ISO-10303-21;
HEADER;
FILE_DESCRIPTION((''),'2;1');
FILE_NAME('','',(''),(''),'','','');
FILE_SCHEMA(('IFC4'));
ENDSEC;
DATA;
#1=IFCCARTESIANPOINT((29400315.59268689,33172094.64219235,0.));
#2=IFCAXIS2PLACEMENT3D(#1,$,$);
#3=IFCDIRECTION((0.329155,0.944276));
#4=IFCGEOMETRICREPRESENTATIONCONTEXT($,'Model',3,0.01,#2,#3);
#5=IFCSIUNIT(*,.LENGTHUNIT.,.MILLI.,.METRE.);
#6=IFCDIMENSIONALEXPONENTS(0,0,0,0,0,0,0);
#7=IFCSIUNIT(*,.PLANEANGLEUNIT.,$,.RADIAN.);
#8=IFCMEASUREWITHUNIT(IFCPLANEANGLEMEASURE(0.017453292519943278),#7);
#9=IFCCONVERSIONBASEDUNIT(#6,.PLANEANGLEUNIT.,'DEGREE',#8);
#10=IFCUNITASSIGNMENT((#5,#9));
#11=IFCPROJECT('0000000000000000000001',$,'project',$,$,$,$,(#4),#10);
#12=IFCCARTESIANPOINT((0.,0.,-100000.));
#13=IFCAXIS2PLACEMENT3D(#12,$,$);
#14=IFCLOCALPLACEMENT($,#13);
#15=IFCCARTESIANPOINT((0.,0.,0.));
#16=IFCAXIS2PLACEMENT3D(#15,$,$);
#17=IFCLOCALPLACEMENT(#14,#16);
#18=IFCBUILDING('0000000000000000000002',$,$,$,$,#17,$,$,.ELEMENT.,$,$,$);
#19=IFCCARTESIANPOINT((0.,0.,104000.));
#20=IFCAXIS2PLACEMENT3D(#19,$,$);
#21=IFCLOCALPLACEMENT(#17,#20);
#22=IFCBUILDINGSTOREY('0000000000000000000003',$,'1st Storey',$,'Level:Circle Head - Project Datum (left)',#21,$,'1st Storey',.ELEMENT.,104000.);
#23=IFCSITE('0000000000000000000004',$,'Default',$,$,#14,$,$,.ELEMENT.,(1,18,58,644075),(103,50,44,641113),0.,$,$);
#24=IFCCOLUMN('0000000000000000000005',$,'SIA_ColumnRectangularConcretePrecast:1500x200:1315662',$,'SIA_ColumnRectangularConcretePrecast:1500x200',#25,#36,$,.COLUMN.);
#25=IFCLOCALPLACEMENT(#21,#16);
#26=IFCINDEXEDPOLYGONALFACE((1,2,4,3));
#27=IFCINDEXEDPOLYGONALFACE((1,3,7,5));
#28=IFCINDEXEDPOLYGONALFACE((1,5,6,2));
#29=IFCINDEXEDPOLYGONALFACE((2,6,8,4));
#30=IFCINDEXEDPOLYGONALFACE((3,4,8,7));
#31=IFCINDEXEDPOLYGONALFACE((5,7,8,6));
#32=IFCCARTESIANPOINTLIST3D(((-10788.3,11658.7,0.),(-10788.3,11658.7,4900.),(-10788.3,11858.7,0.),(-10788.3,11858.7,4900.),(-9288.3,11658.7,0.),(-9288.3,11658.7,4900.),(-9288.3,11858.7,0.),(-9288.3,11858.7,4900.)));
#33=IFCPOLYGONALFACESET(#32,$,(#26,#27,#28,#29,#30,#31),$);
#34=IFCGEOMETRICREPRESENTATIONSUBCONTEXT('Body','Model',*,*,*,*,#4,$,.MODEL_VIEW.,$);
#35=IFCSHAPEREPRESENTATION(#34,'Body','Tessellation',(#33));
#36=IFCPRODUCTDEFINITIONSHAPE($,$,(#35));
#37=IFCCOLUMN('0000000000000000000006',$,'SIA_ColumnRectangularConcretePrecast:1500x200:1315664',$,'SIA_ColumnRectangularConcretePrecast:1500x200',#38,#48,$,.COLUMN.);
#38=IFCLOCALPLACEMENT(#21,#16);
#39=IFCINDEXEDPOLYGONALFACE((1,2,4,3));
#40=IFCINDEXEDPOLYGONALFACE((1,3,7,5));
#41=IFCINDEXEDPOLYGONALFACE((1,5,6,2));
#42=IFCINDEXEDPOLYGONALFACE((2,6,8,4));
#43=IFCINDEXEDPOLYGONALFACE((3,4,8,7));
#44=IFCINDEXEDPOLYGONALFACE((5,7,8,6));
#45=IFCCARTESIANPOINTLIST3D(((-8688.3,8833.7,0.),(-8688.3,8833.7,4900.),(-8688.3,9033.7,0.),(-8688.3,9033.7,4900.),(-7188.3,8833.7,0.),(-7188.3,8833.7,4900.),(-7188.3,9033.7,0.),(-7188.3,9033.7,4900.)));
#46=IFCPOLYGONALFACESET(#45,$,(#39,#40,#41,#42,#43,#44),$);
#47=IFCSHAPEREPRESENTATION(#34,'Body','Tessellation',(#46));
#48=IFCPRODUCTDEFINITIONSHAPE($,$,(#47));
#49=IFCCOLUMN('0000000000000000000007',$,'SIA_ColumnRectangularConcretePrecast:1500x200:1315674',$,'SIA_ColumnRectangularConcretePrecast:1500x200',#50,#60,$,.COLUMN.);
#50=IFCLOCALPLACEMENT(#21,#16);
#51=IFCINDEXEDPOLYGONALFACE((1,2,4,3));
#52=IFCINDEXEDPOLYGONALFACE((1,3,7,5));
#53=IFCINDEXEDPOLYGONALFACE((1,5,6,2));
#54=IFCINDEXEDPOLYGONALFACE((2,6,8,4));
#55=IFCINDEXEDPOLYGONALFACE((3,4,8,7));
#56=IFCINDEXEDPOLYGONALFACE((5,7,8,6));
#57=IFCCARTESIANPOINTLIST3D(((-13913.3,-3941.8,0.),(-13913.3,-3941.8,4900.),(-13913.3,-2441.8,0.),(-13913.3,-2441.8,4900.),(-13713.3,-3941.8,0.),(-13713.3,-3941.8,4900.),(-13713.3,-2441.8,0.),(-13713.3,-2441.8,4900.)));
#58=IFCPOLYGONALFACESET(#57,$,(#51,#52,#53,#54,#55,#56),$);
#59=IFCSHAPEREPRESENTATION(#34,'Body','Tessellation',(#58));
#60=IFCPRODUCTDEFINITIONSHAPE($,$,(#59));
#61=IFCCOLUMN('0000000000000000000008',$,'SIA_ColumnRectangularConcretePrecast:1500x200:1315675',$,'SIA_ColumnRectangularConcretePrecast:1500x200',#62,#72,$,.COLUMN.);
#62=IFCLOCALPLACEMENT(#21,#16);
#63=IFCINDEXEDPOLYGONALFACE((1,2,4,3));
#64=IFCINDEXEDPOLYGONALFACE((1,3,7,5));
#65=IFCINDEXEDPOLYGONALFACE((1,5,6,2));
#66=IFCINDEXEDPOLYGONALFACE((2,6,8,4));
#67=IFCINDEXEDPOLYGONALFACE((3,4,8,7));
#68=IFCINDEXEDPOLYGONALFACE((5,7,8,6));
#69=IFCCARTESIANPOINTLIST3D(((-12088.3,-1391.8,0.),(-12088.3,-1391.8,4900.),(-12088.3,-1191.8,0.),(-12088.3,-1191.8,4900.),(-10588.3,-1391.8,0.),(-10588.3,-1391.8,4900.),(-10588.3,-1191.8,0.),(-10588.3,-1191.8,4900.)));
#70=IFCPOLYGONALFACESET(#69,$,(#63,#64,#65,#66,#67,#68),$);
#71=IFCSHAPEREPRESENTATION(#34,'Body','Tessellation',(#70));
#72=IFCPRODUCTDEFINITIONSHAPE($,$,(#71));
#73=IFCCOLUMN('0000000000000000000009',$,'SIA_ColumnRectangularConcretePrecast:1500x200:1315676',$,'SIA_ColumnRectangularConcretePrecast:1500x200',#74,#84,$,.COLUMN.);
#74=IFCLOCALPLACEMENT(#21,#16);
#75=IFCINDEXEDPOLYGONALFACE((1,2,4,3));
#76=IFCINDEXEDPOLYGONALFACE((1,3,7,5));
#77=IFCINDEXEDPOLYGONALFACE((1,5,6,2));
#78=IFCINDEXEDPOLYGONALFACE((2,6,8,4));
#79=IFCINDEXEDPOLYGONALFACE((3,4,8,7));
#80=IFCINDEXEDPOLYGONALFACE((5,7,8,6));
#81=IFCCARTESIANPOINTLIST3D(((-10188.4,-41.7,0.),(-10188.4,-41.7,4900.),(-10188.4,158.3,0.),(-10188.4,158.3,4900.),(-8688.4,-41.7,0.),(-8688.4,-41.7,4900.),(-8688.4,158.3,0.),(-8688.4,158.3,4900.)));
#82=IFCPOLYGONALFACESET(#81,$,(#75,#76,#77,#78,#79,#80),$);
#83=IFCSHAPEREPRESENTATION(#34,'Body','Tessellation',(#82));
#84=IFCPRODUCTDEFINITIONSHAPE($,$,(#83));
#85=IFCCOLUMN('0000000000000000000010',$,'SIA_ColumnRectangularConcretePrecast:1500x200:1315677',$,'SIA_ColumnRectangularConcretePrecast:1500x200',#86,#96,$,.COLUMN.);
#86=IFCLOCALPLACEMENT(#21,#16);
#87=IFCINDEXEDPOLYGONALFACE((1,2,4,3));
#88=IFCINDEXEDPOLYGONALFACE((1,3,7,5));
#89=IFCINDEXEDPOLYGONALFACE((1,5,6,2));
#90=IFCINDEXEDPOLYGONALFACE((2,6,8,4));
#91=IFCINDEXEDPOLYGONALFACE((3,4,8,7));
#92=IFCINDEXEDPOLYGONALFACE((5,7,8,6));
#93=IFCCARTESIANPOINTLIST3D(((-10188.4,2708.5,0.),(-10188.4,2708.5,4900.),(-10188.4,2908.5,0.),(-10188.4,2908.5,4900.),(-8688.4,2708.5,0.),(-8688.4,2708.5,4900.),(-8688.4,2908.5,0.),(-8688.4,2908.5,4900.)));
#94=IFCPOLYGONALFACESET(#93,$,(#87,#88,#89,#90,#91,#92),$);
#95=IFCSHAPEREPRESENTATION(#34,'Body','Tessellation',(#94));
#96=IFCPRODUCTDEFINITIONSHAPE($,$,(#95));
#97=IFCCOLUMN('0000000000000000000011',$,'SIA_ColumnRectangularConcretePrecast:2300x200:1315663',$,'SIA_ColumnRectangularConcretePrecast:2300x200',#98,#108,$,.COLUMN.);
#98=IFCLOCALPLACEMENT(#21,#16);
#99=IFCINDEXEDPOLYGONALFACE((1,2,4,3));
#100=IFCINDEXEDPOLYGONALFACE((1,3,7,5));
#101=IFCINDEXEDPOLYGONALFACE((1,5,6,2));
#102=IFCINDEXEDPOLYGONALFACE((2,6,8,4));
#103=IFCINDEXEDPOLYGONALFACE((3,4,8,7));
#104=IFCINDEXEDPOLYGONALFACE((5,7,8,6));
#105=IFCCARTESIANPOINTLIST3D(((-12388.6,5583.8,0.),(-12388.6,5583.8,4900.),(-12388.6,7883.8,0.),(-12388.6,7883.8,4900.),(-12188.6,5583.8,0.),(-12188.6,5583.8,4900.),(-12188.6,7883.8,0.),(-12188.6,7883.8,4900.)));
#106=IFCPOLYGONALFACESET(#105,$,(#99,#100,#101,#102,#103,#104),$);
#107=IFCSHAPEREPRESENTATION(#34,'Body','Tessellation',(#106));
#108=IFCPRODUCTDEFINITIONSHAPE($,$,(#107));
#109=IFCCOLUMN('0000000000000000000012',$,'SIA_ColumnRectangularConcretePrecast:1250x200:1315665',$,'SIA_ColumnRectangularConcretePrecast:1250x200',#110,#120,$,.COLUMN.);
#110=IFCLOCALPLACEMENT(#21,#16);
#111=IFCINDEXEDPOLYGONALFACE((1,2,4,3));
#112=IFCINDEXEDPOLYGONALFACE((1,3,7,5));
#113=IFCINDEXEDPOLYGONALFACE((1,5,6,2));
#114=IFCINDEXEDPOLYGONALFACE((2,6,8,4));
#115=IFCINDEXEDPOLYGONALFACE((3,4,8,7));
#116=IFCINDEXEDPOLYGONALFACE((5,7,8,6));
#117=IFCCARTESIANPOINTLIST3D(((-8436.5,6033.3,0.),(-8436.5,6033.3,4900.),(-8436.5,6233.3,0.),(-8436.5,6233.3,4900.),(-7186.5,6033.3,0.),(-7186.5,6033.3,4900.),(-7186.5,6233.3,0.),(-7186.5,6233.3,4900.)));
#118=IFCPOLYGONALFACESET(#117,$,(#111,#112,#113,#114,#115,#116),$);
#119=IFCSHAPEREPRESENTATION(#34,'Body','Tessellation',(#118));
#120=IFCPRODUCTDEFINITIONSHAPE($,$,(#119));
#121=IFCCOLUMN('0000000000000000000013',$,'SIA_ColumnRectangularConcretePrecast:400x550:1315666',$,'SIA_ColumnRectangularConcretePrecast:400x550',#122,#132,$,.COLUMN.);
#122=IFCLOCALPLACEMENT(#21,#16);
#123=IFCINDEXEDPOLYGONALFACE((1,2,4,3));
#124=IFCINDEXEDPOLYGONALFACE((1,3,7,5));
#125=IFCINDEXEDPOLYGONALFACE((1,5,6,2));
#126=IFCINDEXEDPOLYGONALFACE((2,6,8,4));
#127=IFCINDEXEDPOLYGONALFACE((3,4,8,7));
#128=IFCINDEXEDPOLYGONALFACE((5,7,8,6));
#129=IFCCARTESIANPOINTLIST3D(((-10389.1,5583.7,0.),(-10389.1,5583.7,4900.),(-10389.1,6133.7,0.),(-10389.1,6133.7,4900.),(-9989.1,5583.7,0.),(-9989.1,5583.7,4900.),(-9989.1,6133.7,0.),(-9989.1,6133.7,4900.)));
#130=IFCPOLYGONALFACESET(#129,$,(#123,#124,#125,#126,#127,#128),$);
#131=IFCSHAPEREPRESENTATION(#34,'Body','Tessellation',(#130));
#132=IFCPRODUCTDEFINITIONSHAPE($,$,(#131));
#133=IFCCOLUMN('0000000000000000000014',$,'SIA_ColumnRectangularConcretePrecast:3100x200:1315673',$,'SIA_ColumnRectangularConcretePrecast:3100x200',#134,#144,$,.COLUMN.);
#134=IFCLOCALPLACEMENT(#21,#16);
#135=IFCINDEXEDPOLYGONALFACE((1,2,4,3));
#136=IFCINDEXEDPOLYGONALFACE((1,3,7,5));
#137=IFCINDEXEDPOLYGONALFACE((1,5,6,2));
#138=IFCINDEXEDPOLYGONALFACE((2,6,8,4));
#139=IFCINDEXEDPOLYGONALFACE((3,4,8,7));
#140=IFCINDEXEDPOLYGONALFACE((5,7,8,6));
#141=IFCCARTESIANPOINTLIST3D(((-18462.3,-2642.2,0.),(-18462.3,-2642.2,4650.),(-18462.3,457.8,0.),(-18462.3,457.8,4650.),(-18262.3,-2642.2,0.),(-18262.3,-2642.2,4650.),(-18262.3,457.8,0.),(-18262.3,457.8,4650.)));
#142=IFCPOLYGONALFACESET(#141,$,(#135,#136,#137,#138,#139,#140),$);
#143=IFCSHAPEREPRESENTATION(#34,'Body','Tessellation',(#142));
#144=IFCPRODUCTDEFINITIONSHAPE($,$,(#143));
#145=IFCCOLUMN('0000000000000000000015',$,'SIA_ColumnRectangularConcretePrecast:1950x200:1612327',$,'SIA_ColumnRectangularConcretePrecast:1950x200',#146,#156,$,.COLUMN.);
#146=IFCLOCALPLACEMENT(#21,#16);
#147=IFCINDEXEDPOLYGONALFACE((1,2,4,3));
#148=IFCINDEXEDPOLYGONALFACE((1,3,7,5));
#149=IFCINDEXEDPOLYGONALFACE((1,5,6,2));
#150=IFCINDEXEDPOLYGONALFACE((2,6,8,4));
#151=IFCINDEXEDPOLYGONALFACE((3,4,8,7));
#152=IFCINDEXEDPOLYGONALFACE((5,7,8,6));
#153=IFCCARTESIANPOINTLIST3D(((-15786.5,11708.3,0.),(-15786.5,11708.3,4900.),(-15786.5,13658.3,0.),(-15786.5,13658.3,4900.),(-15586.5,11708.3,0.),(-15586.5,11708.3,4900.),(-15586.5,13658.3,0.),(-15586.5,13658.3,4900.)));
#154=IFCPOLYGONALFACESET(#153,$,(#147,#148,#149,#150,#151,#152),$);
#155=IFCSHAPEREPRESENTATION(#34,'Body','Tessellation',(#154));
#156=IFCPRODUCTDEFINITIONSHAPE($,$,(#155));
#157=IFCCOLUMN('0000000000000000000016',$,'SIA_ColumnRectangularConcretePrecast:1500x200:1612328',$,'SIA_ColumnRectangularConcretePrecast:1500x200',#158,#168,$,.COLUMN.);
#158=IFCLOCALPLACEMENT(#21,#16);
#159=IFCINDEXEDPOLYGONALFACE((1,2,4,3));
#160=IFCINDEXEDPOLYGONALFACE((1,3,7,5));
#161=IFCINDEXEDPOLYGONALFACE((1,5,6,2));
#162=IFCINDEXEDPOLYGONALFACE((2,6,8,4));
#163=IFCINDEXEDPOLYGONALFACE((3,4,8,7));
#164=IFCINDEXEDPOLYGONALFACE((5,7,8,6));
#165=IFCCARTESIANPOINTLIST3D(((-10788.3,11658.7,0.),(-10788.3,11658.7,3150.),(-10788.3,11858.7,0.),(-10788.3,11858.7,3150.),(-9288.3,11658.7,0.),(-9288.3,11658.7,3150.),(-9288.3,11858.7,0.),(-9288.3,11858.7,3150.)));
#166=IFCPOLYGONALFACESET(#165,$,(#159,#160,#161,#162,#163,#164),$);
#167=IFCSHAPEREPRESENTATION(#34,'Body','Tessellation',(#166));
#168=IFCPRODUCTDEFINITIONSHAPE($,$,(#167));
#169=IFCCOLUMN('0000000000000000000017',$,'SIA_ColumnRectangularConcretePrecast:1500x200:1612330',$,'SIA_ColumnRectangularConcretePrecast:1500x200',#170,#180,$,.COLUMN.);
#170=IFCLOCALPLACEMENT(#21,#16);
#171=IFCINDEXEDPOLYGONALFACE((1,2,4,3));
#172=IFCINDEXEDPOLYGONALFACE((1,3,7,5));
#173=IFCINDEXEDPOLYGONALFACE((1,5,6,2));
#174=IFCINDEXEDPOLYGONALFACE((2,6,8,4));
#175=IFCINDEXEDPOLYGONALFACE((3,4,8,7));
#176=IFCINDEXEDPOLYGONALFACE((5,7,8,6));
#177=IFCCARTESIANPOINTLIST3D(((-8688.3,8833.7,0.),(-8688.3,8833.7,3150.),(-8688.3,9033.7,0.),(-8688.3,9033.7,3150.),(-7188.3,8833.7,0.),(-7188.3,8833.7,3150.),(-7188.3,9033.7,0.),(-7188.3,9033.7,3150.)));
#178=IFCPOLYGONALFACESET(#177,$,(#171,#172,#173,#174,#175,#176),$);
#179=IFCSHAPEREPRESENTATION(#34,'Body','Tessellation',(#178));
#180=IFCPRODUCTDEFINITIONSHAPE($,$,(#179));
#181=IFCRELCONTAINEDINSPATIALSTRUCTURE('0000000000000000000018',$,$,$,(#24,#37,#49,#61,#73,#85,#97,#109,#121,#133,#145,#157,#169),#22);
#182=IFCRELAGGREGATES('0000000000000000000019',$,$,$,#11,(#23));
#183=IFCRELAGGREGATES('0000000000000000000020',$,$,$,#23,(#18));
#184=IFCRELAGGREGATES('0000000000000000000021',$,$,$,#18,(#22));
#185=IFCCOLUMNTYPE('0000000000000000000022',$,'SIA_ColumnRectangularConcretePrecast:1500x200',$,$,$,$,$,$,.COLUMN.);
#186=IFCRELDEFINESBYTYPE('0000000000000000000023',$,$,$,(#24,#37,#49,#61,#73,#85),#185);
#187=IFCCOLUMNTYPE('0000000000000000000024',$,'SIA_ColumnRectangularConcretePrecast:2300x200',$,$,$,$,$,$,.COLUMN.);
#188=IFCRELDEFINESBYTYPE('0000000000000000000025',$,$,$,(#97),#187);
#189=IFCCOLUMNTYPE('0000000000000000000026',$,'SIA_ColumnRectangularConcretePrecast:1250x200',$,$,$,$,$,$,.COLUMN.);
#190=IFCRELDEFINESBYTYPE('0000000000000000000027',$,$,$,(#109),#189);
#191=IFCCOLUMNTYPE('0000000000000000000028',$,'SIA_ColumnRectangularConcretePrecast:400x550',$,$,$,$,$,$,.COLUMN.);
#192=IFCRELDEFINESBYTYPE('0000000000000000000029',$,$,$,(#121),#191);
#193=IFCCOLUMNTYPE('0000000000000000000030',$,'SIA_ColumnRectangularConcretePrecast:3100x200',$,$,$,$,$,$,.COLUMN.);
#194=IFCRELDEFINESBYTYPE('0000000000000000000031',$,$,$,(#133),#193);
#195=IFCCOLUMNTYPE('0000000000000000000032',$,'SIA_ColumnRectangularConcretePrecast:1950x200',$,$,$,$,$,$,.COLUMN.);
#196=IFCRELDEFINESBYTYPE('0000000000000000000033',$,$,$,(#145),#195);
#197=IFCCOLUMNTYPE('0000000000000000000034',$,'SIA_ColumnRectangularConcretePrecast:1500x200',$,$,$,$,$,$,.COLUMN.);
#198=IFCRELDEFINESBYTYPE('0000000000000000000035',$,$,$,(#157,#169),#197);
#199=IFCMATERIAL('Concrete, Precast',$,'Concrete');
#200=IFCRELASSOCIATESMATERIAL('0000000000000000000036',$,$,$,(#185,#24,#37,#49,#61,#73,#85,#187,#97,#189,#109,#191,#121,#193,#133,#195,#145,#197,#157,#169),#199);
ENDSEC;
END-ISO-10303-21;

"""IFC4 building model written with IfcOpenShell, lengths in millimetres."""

from ifc_helpers import new_model, entity, si_unit, converted_unit, direction, frame, origin, place, context, subcontext, project, spatial, indexed_curve, outline, extrude, source, transform, mapped, material, type_object, type_shapes, element, save


model = new_model("IFC4")

# Units and contexts
model_context = context("Model", 3, precision=0.01, world=frame((29400315.59268689, 33172094.64219235, 0.0)), true_north=direction((0.329155, 0.944276)))
body_context = subcontext(model_context, "Body", "Model", "MODEL_VIEW")
ifc_project = project(units=[si_unit("LENGTHUNIT", "METRE", prefix="MILLI"), converted_unit("PLANEANGLEUNIT", "DEGREE", entity("IfcPlaneAngleMeasure", 0.017453292519943278), si_unit("PLANEANGLEUNIT", "RADIAN"), dimensions=[0, 0, 0, 0, 0, 0, 0])], contexts=[model_context])

# Site, building, storey
site_placement = place(None, frame((0.0, 0.0, -100000.0)))
site = spatial("IfcSite", under=ifc_project, at=site_placement, Name="Default", CompositionType="ELEMENT", RefLatitude=(1, 18, 58, 644075), RefLongitude=(103, 50, 44, 641113), RefElevation=0.0)
building_placement = place(site_placement, origin())
building = spatial("IfcBuilding", under=site, at=building_placement, CompositionType="ELEMENT")
storey_placement = place(building_placement, frame((0.0, 0.0, 104000.0)))
storey = spatial("IfcBuildingStorey", under=building, at=storey_placement, Name="1st Storey", ObjectType="Level:Circle Head - Project Datum (left)", LongName="1st Storey", CompositionType="ELEMENT", Elevation=104000.0)

# Columns
ifc_material = material(Name="Concrete, Precast", Category="Concrete")
column_type_1 = type_object("IfcColumnType", Name="SIA_ColumnRectangularConcretePrecast:1500x200", PredefinedType="COLUMN", material=ifc_material)
shared_shape_1 = source(origin(), body_context, "Body", "SweptSolid", [
    extrude(outline(indexed_curve([(-100.0, -750.0), (100.0, -750.0), (100.0, 750.0), (-100.0, 750.0), (-100.0, -750.0)], self_intersect=False)), frame((0.0, 0.0, 104000.0), z_axis=(0.0, 0.0, 1.0), x_axis=(-1.0, 0.0, 0.0)), (0.0, 0.0, 1.0), 4900.0),
])
type_shapes(column_type_1, [shared_shape_1])
for number, where, z_axis, x_axis, name in (
    (1, (-10038.3, 11758.7, -104000.0), (0.0, 0.0, 1.0), (0.0, -1.0, 0.0), "SIA_ColumnRectangularConcretePrecast:1500x200:1315662"),
    (2, (-7938.3, 8933.7, -104000.0), (0.0, 0.0, 1.0), (0.0, 1.0, 0.0), "SIA_ColumnRectangularConcretePrecast:1500x200:1315664"),
):
    element("IfcColumn", number, at=place(storey_placement, frame(where, z_axis=z_axis, x_axis=x_axis)), inside=storey, type_object=column_type_1, material=ifc_material, Name=name, ObjectType="SIA_ColumnRectangularConcretePrecast:1500x200", PredefinedType="COLUMN", context=body_context, shape_type="MappedRepresentation", body=[
        mapped(shared_shape_1, transform((0.0, 0.0, 0.0), scale=1.0)),
    ])
column_1_placement = place(storey_placement, frame((-13813.3, -3191.8, -104000.0)))
element("IfcColumn", 3, at=column_1_placement, inside=storey, type_object=column_type_1, material=ifc_material, Name="SIA_ColumnRectangularConcretePrecast:1500x200:1315674", ObjectType="SIA_ColumnRectangularConcretePrecast:1500x200", PredefinedType="COLUMN", context=body_context, shape_type="MappedRepresentation", body=[
    mapped(shared_shape_1, transform((0.0, 0.0, 0.0), scale=1.0)),
])
for number, where, z_axis, x_axis, name in (
    (4, (-11338.3, -1291.8, -104000.0), (0.0, 0.0, 1.0), (0.0, -1.0, 0.0), "SIA_ColumnRectangularConcretePrecast:1500x200:1315675"),
    (5, (-9438.4, 58.3, -104000.0), (0.0, 0.0, 1.0), (0.0, -1.0, 0.0), "SIA_ColumnRectangularConcretePrecast:1500x200:1315676"),
    (6, (-9438.4, 2808.5, -104000.0), (0.0, 0.0, 1.0), (0.0, -1.0, 0.0), "SIA_ColumnRectangularConcretePrecast:1500x200:1315677"),
):
    element("IfcColumn", number, at=place(storey_placement, frame(where, z_axis=z_axis, x_axis=x_axis)), inside=storey, type_object=column_type_1, material=ifc_material, Name=name, ObjectType="SIA_ColumnRectangularConcretePrecast:1500x200", PredefinedType="COLUMN", context=body_context, shape_type="MappedRepresentation", body=[
        mapped(shared_shape_1, transform((0.0, 0.0, 0.0), scale=1.0)),
    ])
column_type_2 = type_object("IfcColumnType", Name="SIA_ColumnRectangularConcretePrecast:2300x200", PredefinedType="COLUMN", material=ifc_material)
shared_shape_2 = source(origin(), body_context, "Body", "SweptSolid", [
    extrude(outline(indexed_curve([(-100.0, -1150.0), (100.0, -1150.0), (100.0, 1150.0), (-100.0, 1150.0), (-100.0, -1150.0)], self_intersect=False)), frame((0.0, 0.0, 104000.0), z_axis=(0.0, 0.0, 1.0), x_axis=(-1.0, 0.0, 0.0)), (0.0, 0.0, 1.0), 4900.0),
])
type_shapes(column_type_2, [shared_shape_2])
column_2_placement = place(storey_placement, frame((-12288.6, 6733.8, -104000.0)))
element("IfcColumn", 7, at=column_2_placement, inside=storey, type_object=column_type_2, material=ifc_material, Name="SIA_ColumnRectangularConcretePrecast:2300x200:1315663", ObjectType="SIA_ColumnRectangularConcretePrecast:2300x200", PredefinedType="COLUMN", context=body_context, shape_type="MappedRepresentation", body=[
    mapped(shared_shape_2, transform((0.0, 0.0, 0.0), scale=1.0)),
])
column_type_3 = type_object("IfcColumnType", Name="SIA_ColumnRectangularConcretePrecast:1250x200", PredefinedType="COLUMN", material=ifc_material)
shared_shape_3 = source(origin(), body_context, "Body", "SweptSolid", [
    extrude(outline(indexed_curve([(-100.0, -625.0), (100.0, -625.0), (100.0, 625.0), (-100.0, 625.0), (-100.0, -625.0)], self_intersect=False)), frame((0.0, 0.0, 104000.0), z_axis=(0.0, 0.0, 1.0), x_axis=(-1.0, 0.0, 0.0)), (0.0, 0.0, 1.0), 4900.0),
])
type_shapes(column_type_3, [shared_shape_3])
column_3_placement = place(storey_placement, frame((-7811.5, 6133.3, -104000.0), z_axis=(0.0, 0.0, 1.0), x_axis=(0.0, 1.0, 0.0)))
element("IfcColumn", 8, at=column_3_placement, inside=storey, type_object=column_type_3, material=ifc_material, Name="SIA_ColumnRectangularConcretePrecast:1250x200:1315665", ObjectType="SIA_ColumnRectangularConcretePrecast:1250x200", PredefinedType="COLUMN", context=body_context, shape_type="MappedRepresentation", body=[
    mapped(shared_shape_3, transform((0.0, 0.0, 0.0), scale=1.0)),
])
column_type_4 = type_object("IfcColumnType", Name="SIA_ColumnRectangularConcretePrecast:400x550", PredefinedType="COLUMN", material=ifc_material)
shared_shape_4 = source(origin(), body_context, "Body", "SweptSolid", [
    extrude(outline(indexed_curve([(-275.0, -200.0), (275.0, -200.0), (275.0, 200.0), (-275.0, 200.0), (-275.0, -200.0)], self_intersect=False)), frame((0.0, 0.0, 104000.0), z_axis=(0.0, 0.0, 1.0), x_axis=(-1.0, 0.0, 0.0)), (0.0, 0.0, 1.0), 4900.0),
])
type_shapes(column_type_4, [shared_shape_4])
column_4_placement = place(storey_placement, frame((-10189.1, 5858.7, -104000.0), z_axis=(0.0, 0.0, 1.0), x_axis=(0.0, -1.0, 0.0)))
element("IfcColumn", 9, at=column_4_placement, inside=storey, type_object=column_type_4, material=ifc_material, Name="SIA_ColumnRectangularConcretePrecast:400x550:1315666", ObjectType="SIA_ColumnRectangularConcretePrecast:400x550", PredefinedType="COLUMN", context=body_context, shape_type="MappedRepresentation", body=[
    mapped(shared_shape_4, transform((0.0, 0.0, 0.0), scale=1.0)),
])
column_type_5 = type_object("IfcColumnType", Name="SIA_ColumnRectangularConcretePrecast:3100x200", PredefinedType="COLUMN", material=ifc_material)
shared_shape_5 = source(origin(), body_context, "Body", "SweptSolid", [
    extrude(outline(indexed_curve([(-100.0, -1550.0), (100.0, -1550.0), (100.0, 1550.0), (-100.0, 1550.0), (-100.0, -1550.0)], self_intersect=False)), frame((-18362.3, -1092.2, 104000.0), z_axis=(0.0, 0.0, 1.0), x_axis=(-1.0, 0.0, 0.0)), (0.0, 0.0, 1.0), 4650.0),
])
type_shapes(column_type_5, [shared_shape_5])
column_5_placement = place(storey_placement, frame((0.0, 0.0, -104000.0)))
element("IfcColumn", 10, at=column_5_placement, inside=storey, type_object=column_type_5, material=ifc_material, Name="SIA_ColumnRectangularConcretePrecast:3100x200:1315673", ObjectType="SIA_ColumnRectangularConcretePrecast:3100x200", PredefinedType="COLUMN", context=body_context, shape_type="MappedRepresentation", body=[
    mapped(shared_shape_5, transform((0.0, 0.0, 0.0), scale=1.0)),
])
column_type_6 = type_object("IfcColumnType", Name="SIA_ColumnRectangularConcretePrecast:1950x200", PredefinedType="COLUMN", material=ifc_material)
shared_shape_6 = source(origin(), body_context, "Body", "SweptSolid", [
    extrude(outline(indexed_curve([(-100.0, -975.0), (100.0, -975.0), (100.0, 975.0), (-100.0, 975.0), (-100.0, -975.0)], self_intersect=False)), frame((0.0, 0.0, 104000.0), z_axis=(0.0, 0.0, 1.0), x_axis=(-1.0, 0.0, 0.0)), (0.0, 0.0, 1.0), 4900.0),
])
type_shapes(column_type_6, [shared_shape_6])
column_6_placement = place(storey_placement, frame((-15686.5, 12683.3, -104000.0)))
element("IfcColumn", 11, at=column_6_placement, inside=storey, type_object=column_type_6, material=ifc_material, Name="SIA_ColumnRectangularConcretePrecast:1950x200:1612327", ObjectType="SIA_ColumnRectangularConcretePrecast:1950x200", PredefinedType="COLUMN", context=body_context, shape_type="MappedRepresentation", body=[
    mapped(shared_shape_6, transform((0.0, 0.0, 0.0), scale=1.0)),
])
column_type_7 = type_object("IfcColumnType", Name="SIA_ColumnRectangularConcretePrecast:1500x200", PredefinedType="COLUMN", material=ifc_material)
shared_shape_7 = source(origin(), body_context, "Body", "SweptSolid", [
    extrude(outline(indexed_curve([(-100.0, -750.0), (100.0, -750.0), (100.0, 750.0), (-100.0, 750.0), (-100.0, -750.0)], self_intersect=False)), frame((0.0, 0.0, 104000.0), z_axis=(0.0, 0.0, 1.0), x_axis=(-1.0, 0.0, 0.0)), (0.0, 0.0, 1.0), 3150.0),
])
type_shapes(column_type_7, [shared_shape_7])
for number, where, z_axis, x_axis, name in (
    (12, (-10038.3, 11758.7, -104000.0), (0.0, 0.0, 1.0), (0.0, -1.0, 0.0), "SIA_ColumnRectangularConcretePrecast:1500x200:1612328"),
    (13, (-7938.3, 8933.7, -104000.0), (0.0, 0.0, 1.0), (0.0, 1.0, 0.0), "SIA_ColumnRectangularConcretePrecast:1500x200:1612330"),
):
    element("IfcColumn", number, at=place(storey_placement, frame(where, z_axis=z_axis, x_axis=x_axis)), inside=storey, type_object=column_type_7, material=ifc_material, Name=name, ObjectType="SIA_ColumnRectangularConcretePrecast:1500x200", PredefinedType="COLUMN", context=body_context, shape_type="MappedRepresentation", body=[
        mapped(shared_shape_7, transform((0.0, 0.0, 0.0), scale=1.0)),
    ])

save(model, "model.ifc")
